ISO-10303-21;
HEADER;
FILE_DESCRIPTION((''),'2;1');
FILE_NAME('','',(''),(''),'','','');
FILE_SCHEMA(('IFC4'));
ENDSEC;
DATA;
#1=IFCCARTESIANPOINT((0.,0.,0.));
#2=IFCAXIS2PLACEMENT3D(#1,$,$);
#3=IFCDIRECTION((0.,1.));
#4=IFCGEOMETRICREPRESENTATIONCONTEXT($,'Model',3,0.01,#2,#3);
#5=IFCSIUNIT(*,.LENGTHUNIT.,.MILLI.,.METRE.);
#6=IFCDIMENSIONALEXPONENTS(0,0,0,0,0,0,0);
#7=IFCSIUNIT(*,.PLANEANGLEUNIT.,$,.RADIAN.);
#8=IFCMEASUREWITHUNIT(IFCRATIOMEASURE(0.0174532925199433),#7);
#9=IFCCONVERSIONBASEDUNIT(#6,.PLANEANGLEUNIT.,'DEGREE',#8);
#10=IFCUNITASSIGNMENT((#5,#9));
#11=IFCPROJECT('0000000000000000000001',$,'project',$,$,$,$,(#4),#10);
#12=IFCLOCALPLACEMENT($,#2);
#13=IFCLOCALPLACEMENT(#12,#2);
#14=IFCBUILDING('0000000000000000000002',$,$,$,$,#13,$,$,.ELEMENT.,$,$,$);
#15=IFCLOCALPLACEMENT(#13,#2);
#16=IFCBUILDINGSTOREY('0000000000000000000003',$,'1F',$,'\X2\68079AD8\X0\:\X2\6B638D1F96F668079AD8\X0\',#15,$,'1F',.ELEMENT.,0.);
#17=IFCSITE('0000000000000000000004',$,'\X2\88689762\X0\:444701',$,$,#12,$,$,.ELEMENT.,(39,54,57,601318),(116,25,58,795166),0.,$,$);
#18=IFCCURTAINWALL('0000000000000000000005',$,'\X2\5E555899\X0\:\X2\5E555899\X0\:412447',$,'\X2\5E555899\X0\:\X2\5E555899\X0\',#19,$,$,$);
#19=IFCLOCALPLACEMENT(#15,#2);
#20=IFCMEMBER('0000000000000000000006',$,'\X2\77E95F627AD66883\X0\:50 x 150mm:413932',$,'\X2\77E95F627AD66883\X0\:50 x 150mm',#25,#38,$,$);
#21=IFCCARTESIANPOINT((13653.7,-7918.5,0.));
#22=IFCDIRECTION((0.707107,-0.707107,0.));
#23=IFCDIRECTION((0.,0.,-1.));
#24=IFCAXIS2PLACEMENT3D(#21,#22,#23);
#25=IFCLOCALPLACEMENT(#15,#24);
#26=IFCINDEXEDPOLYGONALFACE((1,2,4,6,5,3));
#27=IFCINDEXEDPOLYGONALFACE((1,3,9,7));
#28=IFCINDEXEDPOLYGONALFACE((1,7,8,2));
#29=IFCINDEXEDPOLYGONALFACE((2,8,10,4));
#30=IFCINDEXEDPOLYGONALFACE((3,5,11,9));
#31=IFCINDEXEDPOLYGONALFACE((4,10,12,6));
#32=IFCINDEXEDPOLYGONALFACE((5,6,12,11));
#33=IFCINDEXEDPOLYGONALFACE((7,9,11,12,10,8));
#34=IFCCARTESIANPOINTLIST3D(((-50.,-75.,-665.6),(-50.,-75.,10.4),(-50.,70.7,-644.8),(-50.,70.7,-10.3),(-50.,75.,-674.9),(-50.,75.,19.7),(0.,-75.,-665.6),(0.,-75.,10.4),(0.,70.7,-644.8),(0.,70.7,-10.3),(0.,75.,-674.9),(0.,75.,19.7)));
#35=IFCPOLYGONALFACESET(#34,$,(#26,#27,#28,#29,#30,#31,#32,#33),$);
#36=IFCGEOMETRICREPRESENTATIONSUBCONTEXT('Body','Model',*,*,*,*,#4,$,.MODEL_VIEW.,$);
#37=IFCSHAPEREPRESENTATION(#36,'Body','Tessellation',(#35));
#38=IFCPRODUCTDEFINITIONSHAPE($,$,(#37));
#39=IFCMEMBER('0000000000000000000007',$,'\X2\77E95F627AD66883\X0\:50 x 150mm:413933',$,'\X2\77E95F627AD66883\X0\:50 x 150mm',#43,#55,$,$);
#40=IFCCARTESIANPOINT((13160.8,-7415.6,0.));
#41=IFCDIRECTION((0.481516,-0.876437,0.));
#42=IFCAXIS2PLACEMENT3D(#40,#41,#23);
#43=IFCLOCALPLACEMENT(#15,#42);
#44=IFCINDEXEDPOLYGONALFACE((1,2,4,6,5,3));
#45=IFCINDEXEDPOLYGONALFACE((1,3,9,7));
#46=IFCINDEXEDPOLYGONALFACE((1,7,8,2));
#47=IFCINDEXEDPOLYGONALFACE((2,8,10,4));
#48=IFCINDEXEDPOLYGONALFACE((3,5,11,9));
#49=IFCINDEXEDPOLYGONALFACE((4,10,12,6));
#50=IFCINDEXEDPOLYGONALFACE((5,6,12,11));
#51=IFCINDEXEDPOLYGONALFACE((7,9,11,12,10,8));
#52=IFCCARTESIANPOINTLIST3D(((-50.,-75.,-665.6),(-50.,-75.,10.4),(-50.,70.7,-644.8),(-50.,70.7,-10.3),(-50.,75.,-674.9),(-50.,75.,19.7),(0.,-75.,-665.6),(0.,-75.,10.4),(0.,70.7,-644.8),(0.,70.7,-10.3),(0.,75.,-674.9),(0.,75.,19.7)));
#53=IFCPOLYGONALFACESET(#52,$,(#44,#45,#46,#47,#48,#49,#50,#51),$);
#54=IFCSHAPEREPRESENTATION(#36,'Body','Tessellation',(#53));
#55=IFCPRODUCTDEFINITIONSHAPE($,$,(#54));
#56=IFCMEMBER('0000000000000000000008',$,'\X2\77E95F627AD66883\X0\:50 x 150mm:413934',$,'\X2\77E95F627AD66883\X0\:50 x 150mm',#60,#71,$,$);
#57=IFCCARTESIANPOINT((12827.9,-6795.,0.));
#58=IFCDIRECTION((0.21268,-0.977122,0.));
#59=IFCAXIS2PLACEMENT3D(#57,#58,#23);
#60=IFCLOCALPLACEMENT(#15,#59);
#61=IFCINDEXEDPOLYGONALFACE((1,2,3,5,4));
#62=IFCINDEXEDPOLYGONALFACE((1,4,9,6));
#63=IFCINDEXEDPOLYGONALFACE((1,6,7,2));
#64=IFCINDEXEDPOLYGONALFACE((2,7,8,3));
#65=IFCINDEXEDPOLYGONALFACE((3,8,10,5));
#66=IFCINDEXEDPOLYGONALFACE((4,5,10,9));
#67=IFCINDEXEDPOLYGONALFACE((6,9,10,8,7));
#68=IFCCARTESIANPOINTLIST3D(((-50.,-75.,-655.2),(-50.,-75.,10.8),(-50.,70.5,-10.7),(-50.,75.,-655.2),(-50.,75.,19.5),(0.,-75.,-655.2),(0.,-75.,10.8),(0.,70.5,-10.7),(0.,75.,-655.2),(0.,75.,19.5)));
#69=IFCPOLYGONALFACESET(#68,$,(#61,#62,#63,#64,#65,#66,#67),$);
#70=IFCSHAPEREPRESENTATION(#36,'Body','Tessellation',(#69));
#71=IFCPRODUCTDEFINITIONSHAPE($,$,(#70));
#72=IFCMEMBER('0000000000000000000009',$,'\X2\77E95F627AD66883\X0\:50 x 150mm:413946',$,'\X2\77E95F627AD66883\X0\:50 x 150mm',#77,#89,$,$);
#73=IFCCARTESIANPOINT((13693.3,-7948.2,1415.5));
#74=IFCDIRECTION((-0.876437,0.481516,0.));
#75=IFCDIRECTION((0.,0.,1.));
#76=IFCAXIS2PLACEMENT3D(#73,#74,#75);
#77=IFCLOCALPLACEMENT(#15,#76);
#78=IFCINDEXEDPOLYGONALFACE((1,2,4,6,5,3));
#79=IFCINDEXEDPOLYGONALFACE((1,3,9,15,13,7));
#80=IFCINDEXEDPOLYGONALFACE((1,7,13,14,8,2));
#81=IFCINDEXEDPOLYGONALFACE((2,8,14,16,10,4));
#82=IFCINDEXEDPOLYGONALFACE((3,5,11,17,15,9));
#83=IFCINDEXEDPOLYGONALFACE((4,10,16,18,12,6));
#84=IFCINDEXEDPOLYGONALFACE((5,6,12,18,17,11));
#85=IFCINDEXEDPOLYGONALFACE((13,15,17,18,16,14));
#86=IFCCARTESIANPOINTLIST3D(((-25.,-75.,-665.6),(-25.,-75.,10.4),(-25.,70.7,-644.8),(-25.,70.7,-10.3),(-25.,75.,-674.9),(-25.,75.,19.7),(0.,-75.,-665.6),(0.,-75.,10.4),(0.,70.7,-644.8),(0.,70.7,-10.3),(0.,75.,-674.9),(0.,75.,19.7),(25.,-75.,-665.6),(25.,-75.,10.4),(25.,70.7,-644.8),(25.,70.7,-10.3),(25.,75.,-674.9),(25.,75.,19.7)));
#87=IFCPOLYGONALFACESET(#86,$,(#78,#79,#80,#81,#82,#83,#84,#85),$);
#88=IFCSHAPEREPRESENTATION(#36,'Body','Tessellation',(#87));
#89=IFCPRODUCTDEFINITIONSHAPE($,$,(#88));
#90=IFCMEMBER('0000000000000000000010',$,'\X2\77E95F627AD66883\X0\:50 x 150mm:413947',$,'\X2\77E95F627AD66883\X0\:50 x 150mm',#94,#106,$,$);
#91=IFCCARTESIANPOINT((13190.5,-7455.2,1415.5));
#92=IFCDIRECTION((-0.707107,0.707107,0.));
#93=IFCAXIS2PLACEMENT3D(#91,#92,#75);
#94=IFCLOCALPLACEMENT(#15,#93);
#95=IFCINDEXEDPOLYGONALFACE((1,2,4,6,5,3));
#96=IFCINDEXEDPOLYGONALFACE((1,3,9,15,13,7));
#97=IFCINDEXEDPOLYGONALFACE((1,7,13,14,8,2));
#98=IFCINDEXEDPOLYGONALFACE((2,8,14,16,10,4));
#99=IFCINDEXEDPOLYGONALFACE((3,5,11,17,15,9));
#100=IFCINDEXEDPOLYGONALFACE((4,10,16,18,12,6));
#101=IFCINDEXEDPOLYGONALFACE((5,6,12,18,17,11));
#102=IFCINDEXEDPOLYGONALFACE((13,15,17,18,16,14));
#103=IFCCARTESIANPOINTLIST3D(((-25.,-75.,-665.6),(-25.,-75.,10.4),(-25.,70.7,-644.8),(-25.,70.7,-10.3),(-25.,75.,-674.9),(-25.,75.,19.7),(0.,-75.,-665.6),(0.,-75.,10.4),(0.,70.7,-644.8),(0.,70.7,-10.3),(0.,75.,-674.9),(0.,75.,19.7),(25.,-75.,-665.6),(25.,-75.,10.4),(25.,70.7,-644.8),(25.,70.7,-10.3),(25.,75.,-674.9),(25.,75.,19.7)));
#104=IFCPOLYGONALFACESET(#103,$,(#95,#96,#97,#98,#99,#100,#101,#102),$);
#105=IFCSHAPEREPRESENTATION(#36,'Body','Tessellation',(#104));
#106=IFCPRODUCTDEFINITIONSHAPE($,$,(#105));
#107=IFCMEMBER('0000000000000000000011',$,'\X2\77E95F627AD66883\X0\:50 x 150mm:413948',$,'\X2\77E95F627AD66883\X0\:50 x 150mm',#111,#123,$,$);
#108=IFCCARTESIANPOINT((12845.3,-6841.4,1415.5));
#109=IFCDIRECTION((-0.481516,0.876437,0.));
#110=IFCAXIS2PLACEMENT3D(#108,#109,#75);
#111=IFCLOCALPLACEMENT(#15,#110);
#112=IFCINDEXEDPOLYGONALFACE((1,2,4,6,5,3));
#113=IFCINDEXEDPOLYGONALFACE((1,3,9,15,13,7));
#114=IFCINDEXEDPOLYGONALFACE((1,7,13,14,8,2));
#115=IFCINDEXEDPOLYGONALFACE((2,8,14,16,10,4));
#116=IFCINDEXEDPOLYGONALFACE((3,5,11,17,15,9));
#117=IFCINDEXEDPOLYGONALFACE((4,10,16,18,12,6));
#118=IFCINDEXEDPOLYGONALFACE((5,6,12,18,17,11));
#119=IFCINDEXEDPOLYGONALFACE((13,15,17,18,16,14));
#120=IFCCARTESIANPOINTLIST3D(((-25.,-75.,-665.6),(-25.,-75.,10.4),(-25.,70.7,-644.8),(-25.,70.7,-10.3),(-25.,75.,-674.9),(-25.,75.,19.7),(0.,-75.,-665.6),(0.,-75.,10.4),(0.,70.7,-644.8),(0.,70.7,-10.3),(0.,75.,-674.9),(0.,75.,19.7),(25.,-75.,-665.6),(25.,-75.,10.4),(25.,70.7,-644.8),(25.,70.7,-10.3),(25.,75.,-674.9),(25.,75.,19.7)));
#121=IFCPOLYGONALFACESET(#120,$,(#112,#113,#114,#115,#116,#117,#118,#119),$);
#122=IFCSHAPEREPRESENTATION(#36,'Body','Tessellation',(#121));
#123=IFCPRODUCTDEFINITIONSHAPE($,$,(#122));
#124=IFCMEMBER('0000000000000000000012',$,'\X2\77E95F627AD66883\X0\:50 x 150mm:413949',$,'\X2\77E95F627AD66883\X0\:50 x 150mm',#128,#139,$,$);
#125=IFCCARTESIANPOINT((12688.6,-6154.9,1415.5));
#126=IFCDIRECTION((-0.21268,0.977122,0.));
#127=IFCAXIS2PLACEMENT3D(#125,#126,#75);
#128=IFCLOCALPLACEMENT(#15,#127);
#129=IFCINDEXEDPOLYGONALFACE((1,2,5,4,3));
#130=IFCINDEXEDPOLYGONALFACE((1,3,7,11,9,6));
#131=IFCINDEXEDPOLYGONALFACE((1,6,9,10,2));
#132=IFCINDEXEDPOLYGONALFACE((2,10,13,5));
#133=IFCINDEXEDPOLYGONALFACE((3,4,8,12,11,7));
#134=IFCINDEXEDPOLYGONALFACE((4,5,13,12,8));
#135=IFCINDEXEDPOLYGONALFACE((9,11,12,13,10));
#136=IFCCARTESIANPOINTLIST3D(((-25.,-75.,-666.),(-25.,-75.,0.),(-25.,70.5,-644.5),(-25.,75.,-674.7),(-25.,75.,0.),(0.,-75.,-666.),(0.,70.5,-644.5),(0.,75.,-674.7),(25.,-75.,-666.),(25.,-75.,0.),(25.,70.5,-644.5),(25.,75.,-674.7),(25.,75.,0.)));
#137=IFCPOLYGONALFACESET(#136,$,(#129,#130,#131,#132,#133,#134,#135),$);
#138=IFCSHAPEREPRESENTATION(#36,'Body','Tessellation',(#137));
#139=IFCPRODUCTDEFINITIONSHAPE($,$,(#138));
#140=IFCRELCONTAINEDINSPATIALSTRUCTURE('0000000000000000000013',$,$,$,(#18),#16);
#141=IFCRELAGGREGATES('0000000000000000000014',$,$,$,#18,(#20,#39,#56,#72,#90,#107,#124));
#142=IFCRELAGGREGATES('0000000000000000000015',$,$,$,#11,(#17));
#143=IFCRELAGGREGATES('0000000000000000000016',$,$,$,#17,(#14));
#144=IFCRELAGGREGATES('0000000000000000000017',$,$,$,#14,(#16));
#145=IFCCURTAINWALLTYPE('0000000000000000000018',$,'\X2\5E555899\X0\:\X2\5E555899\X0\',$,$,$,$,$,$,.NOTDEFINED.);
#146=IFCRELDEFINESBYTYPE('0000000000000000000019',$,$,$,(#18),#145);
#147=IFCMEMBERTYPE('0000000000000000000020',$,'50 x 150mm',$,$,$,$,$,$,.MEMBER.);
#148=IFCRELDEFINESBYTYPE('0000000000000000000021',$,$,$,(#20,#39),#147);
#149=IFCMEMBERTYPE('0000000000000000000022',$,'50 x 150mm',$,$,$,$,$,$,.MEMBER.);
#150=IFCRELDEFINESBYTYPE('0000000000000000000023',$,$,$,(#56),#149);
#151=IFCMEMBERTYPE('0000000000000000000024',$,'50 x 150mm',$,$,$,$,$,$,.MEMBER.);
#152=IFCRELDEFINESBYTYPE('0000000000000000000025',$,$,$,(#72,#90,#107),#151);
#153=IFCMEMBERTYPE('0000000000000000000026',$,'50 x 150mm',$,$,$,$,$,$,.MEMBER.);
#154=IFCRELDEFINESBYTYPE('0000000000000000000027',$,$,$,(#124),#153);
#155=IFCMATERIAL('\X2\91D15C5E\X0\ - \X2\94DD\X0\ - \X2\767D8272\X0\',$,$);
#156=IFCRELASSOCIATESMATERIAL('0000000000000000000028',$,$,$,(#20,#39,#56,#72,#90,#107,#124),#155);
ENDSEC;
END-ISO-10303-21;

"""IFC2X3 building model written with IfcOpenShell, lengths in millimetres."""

from ifc_helpers import new_model, entity, si_unit, converted_unit, direction, frame, origin, origin_2d_with_axis, place, context, subcontext, project, spatial, polyline, rectangle, extrude, clip, bounded_halfspace, source, transform, mapped, material, type_object, type_shapes, element, aggregate, save


model = new_model("IFC2X3")

# Units and contexts
model_context = context("Model", 3, precision=0.01, world=origin(), true_north=direction((0.0, 1.0)))
body_context = subcontext(model_context, "Body", "Model", "MODEL_VIEW")
ifc_project = project(units=[si_unit("LENGTHUNIT", "METRE", prefix="MILLI"), converted_unit("PLANEANGLEUNIT", "DEGREE", entity("IfcRatioMeasure", 0.0174532925199433), si_unit("PLANEANGLEUNIT", "RADIAN"), dimensions=[0, 0, 0, 0, 0, 0, 0])], contexts=[model_context])

# Site, building, storey
site_placement = place(None, origin())
site = spatial("IfcSite", under=ifc_project, at=site_placement, Name="表面:444701", CompositionType="ELEMENT", RefLatitude=(39, 54, 57, 601318), RefLongitude=(116, 25, 58, 795166), RefElevation=0.0)
building_placement = place(site_placement, origin())
building = spatial("IfcBuilding", under=site, at=building_placement, CompositionType="ELEMENT")
storey_placement = place(building_placement, origin())
storey = spatial("IfcBuildingStorey", under=building, at=storey_placement, Name="1F", ObjectType="标高:正负零标高", LongName="1F", CompositionType="ELEMENT", Elevation=0.0)

# Curtain wall, members
curtain_wall_type = type_object("IfcCurtainWallType", Name="幕墙:幕墙", PredefinedType="NOTDEFINED")
curtain_wall_placement = place(storey_placement, origin())
curtain_wall = element("IfcCurtainWall", 1, at=curtain_wall_placement, inside=storey, type_object=curtain_wall_type, Name="幕墙:幕墙:412447", ObjectType="幕墙:幕墙")
ifc_material_1 = material(Name="金属 - 铝 - 白色")
member_type_1 = type_object("IfcMemberType", Name="50 x 150mm", PredefinedType="MEMBER")
shared_shape_1 = source(origin(), body_context, "Body", "Clipping", [
    clip(clip(clip(clip(extrude(rectangle(XDim=50.0, YDim=150.0, at=origin_2d_with_axis()), frame((-25.0, 0.0, -674.9)), (0.0, 0.0, 1.0), 694.5), bounded_halfspace(frame((0.0, 70.7, -644.8), z_axis=(0.0, 0.141035, -0.990005), x_axis=(-1.0, 0.0, 0.0)), False, frame((-25.0, 0.0, -674.9)), polyline([(25.0, 70.7), (25.0, -75.0), (-25.0, -75.0), (-25.0, 70.7), (25.0, 70.7)]))), bounded_halfspace(frame((0.0, 77.8, -694.3), z_axis=(0.0, -0.990005, -0.141035), x_axis=(-1.0, 0.0, 0.0)), False, frame((-25.0, 0.0, -674.9)), polyline([(25.0, 75.0), (25.0, 70.7), (-25.0, 70.7), (-25.0, 75.0), (25.0, 75.0)]))), bounded_halfspace(frame((0.0, 70.7, -10.3), z_axis=(0.0, -0.990005, 0.141035), x_axis=(-1.0, 0.0, 0.0)), False, frame((-25.0, 0.0, -674.9)), polyline([(25.0, 75.0), (-25.0, 75.0), (-25.0, 70.7), (25.0, 70.7), (25.0, 75.0)]))), bounded_halfspace(frame((0.0, -77.8, 10.8), z_axis=(0.0, 0.141035, 0.990005), x_axis=(-1.0, 0.0, 0.0)), False, frame((-25.0, 0.0, -674.9)), polyline([(-25.0, 70.7), (-25.0, -75.0), (25.0, -75.0), (25.0, 70.7), (-25.0, 70.7)]))),
])
type_shapes(member_type_1, [shared_shape_1])
member_1_placement = place(storey_placement, frame((13653.7, -7918.5, 0.0), z_axis=(0.707107, -0.707107, 0.0), x_axis=(0.0, 0.0, -1.0)))
member_1 = element("IfcMember", 2, at=member_1_placement, type_object=member_type_1, material=ifc_material_1, Name="矩形竖梃:50 x 150mm:413932", ObjectType="矩形竖梃:50 x 150mm", context=body_context, shape_type="MappedRepresentation", body=[
    mapped(shared_shape_1, transform((0.0, 0.0, 0.0), scale=1.0)),
])
member_2_placement = place(storey_placement, frame((13160.8, -7415.6, 0.0), z_axis=(0.481516, -0.876437, 0.0), x_axis=(0.0, 0.0, -1.0)))
member_2 = element("IfcMember", 3, at=member_2_placement, type_object=member_type_1, material=ifc_material_1, Name="矩形竖梃:50 x 150mm:413933", ObjectType="矩形竖梃:50 x 150mm", context=body_context, shape_type="MappedRepresentation", body=[
    mapped(shared_shape_1, transform((0.0, 0.0, 0.0), scale=1.0)),
])
member_type_2 = type_object("IfcMemberType", Name="50 x 150mm", PredefinedType="MEMBER")
shared_shape_2 = source(origin(), body_context, "Body", "Clipping", [
    clip(clip(extrude(rectangle(XDim=50.0, YDim=150.0, at=origin_2d_with_axis()), frame((-25.0, 0.0, -655.2)), (0.0, 0.0, 1.0), 674.7), bounded_halfspace(frame((0.0, 70.5, -10.7), z_axis=(0.0, -0.989279, 0.146035), x_axis=(-1.0, 0.0, 0.0)), False, frame((-25.0, 0.0, -655.2)), polyline([(25.0, 75.0), (-25.0, 75.0), (-25.0, 70.5), (25.0, 70.5), (25.0, 75.0)]))), bounded_halfspace(frame((0.0, -77.8, 11.2), z_axis=(0.0, 0.146035, 0.989279), x_axis=(-1.0, 0.0, 0.0)), False, frame((-25.0, 0.0, -655.2)), polyline([(-25.0, 70.5), (-25.0, -75.0), (25.0, -75.0), (25.0, 70.5), (-25.0, 70.5)]))),
])
type_shapes(member_type_2, [shared_shape_2])
member_3_placement = place(storey_placement, frame((12827.9, -6795.0, 0.0), z_axis=(0.21268, -0.977122, 0.0), x_axis=(0.0, 0.0, -1.0)))
member_3 = element("IfcMember", 4, at=member_3_placement, type_object=member_type_2, material=ifc_material_1, Name="矩形竖梃:50 x 150mm:413934", ObjectType="矩形竖梃:50 x 150mm", context=body_context, shape_type="MappedRepresentation", body=[
    mapped(shared_shape_2, transform((0.0, 0.0, 0.0), scale=1.0)),
])
member_type_3 = type_object("IfcMemberType", Name="50 x 150mm", PredefinedType="MEMBER")
shared_shape_3 = source(origin(), body_context, "Body", "Clipping", [
    clip(clip(clip(clip(clip(clip(clip(clip(extrude(rectangle(XDim=150.0, YDim=50.0, at=origin_2d_with_axis()), frame((0.0, 0.0, -674.9), z_axis=(0.0, 0.0, 1.0), x_axis=(0.0, -1.0, 0.0)), (0.0, 0.0, 1.0), 694.5), bounded_halfspace(frame((-1415.5, -77.8, -666.0), z_axis=(0.0, 0.141035, -0.990005), x_axis=(1.0, 0.0, 0.0)), False, frame((0.0, 0.0, -674.9), z_axis=(0.0, 0.0, 1.0), x_axis=(0.0, -1.0, 0.0)), polyline([(75.0, 0.0), (75.0, -25.0), (-70.7, -25.0), (-70.7, 0.0), (75.0, 0.0)]))), bounded_halfspace(frame((0.0, -77.8, -666.0), z_axis=(0.0, 0.141035, -0.990005), x_axis=(1.0, 0.0, 0.0)), False, frame((0.0, 0.0, -674.9), z_axis=(0.0, 0.0, 1.0), x_axis=(0.0, -1.0, 0.0)), polyline([(-70.7, 25.0), (75.0, 25.0), (75.0, 0.0), (-70.7, 0.0), (-70.7, 25.0)]))), bounded_halfspace(frame((-1415.5, 70.7, -644.8), z_axis=(0.0, -0.990005, -0.141035), x_axis=(1.0, 0.0, 0.0)), False, frame((0.0, 0.0, -674.9), z_axis=(0.0, 0.0, 1.0), x_axis=(0.0, -1.0, 0.0)), polyline([(-70.7, -25.0), (-75.0, -25.0), (-75.0, 0.0), (-70.7, 0.0), (-70.7, -25.0)]))), bounded_halfspace(frame((0.0, 70.7, -644.8), z_axis=(0.0, -0.990005, -0.141035), x_axis=(1.0, 0.0, 0.0)), False, frame((0.0, 0.0, -674.9), z_axis=(0.0, 0.0, 1.0), x_axis=(0.0, -1.0, 0.0)), polyline([(-75.0, 25.0), (-70.7, 25.0), (-70.7, 0.0), (-75.0, 0.0), (-75.0, 25.0)]))), bounded_halfspace(frame((-1415.5, 77.8, 39.2), z_axis=(0.0, -0.990005, 0.141035), x_axis=(1.0, 0.0, 0.0)), False, frame((0.0, 0.0, -674.9), z_axis=(0.0, 0.0, 1.0), x_axis=(0.0, -1.0, 0.0)), polyline([(-75.0, 0.0), (-75.0, -25.0), (-70.7, -25.0), (-70.7, 0.0), (-75.0, 0.0)]))), bounded_halfspace(frame((0.0, 77.8, 39.2), z_axis=(0.0, -0.990005, 0.141035), x_axis=(1.0, 0.0, 0.0)), False, frame((0.0, 0.0, -674.9), z_axis=(0.0, 0.0, 1.0), x_axis=(0.0, -1.0, 0.0)), polyline([(-75.0, 25.0), (-75.0, 0.0), (-70.7, 0.0), (-70.7, 25.0), (-75.0, 25.0)]))), bounded_halfspace(frame((-1415.5, 70.7, -10.3), z_axis=(0.0, 0.141035, 0.990005), x_axis=(1.0, 0.0, 0.0)), False, frame((0.0, 0.0, -674.9), z_axis=(0.0, 0.0, 1.0), x_axis=(0.0, -1.0, 0.0)), polyline([(-70.7, -25.0), (75.0, -25.0), (75.0, 0.0), (-70.7, 0.0), (-70.7, -25.0)]))), bounded_halfspace(frame((0.0, 70.7, -10.3), z_axis=(0.0, 0.141035, 0.990005), x_axis=(1.0, 0.0, 0.0)), False, frame((0.0, 0.0, -674.9), z_axis=(0.0, 0.0, 1.0), x_axis=(0.0, -1.0, 0.0)), polyline([(75.0, 0.0), (75.0, 25.0), (-70.7, 25.0), (-70.7, 0.0), (75.0, 0.0)]))),
])
type_shapes(member_type_3, [shared_shape_3])
member_4_placement = place(storey_placement, frame((13693.3, -7948.2, 1415.5), z_axis=(-0.876437, 0.481516, 0.0), x_axis=(0.0, 0.0, 1.0)))
member_4 = element("IfcMember", 5, at=member_4_placement, type_object=member_type_3, material=ifc_material_1, Name="矩形竖梃:50 x 150mm:413946", ObjectType="矩形竖梃:50 x 150mm", context=body_context, shape_type="MappedRepresentation", body=[
    mapped(shared_shape_3, transform((0.0, 0.0, 0.0), scale=1.0)),
])
member_5_placement = place(storey_placement, frame((13190.5, -7455.2, 1415.5), z_axis=(-0.707107, 0.707107, 0.0), x_axis=(0.0, 0.0, 1.0)))
member_5 = element("IfcMember", 6, at=member_5_placement, type_object=member_type_3, material=ifc_material_1, Name="矩形竖梃:50 x 150mm:413947", ObjectType="矩形竖梃:50 x 150mm", context=body_context, shape_type="MappedRepresentation", body=[
    mapped(shared_shape_3, transform((0.0, 0.0, 0.0), scale=1.0)),
])
member_6_placement = place(storey_placement, frame((12845.3, -6841.4, 1415.5), z_axis=(-0.481516, 0.876437, 0.0), x_axis=(0.0, 0.0, 1.0)))
member_6 = element("IfcMember", 7, at=member_6_placement, type_object=member_type_3, material=ifc_material_1, Name="矩形竖梃:50 x 150mm:413948", ObjectType="矩形竖梃:50 x 150mm", context=body_context, shape_type="MappedRepresentation", body=[
    mapped(shared_shape_3, transform((0.0, 0.0, 0.0), scale=1.0)),
])
member_type_4 = type_object("IfcMemberType", Name="50 x 150mm", PredefinedType="MEMBER")
shared_shape_4 = source(origin(), body_context, "Body", "Clipping", [
    clip(clip(clip(clip(extrude(rectangle(XDim=150.0, YDim=50.0, at=origin_2d_with_axis()), frame((0.0, 0.0, -674.7), z_axis=(0.0, 0.0, 1.0), x_axis=(0.0, -1.0, 0.0)), (0.0, 0.0, 1.0), 674.7), bounded_halfspace(frame((-1415.5, -77.8, -666.4), z_axis=(0.0, 0.146035, -0.989279), x_axis=(1.0, 0.0, 0.0)), False, frame((0.0, 0.0, -674.7), z_axis=(0.0, 0.0, 1.0), x_axis=(0.0, -1.0, 0.0)), polyline([(75.0, 0.0), (75.0, -25.0), (-70.5, -25.0), (-70.5, 0.0), (75.0, 0.0)]))), bounded_halfspace(frame((0.0, -77.8, -666.4), z_axis=(0.0, 0.146035, -0.989279), x_axis=(1.0, 0.0, 0.0)), False, frame((0.0, 0.0, -674.7), z_axis=(0.0, 0.0, 1.0), x_axis=(0.0, -1.0, 0.0)), polyline([(-70.5, 25.0), (75.0, 25.0), (75.0, 0.0), (-70.5, 0.0), (-70.5, 25.0)]))), bounded_halfspace(frame((-1415.5, 70.5, -644.5), z_axis=(0.0, -0.989279, -0.146035), x_axis=(1.0, 0.0, 0.0)), False, frame((0.0, 0.0, -674.7), z_axis=(0.0, 0.0, 1.0), x_axis=(0.0, -1.0, 0.0)), polyline([(-70.5, -25.0), (-75.0, -25.0), (-75.0, 0.0), (-70.5, 0.0), (-70.5, -25.0)]))), bounded_halfspace(frame((0.0, 70.5, -644.5), z_axis=(0.0, -0.989279, -0.146035), x_axis=(1.0, 0.0, 0.0)), False, frame((0.0, 0.0, -674.7), z_axis=(0.0, 0.0, 1.0), x_axis=(0.0, -1.0, 0.0)), polyline([(-75.0, 25.0), (-70.5, 25.0), (-70.5, 0.0), (-75.0, 0.0), (-75.0, 25.0)]))),
])
type_shapes(member_type_4, [shared_shape_4])
member_7_placement = place(storey_placement, frame((12688.6, -6154.9, 1415.5), z_axis=(-0.21268, 0.977122, 0.0), x_axis=(0.0, 0.0, 1.0)))
member_7 = element("IfcMember", 8, at=member_7_placement, type_object=member_type_4, material=ifc_material_1, Name="矩形竖梃:50 x 150mm:413949", ObjectType="矩形竖梃:50 x 150mm", context=body_context, shape_type="MappedRepresentation", body=[
    mapped(shared_shape_4, transform((0.0, 0.0, 0.0), scale=1.0)),
])
aggregate(curtain_wall, [member_1, member_2, member_3, member_4, member_5, member_6, member_7])

save(model, "model.ifc")
